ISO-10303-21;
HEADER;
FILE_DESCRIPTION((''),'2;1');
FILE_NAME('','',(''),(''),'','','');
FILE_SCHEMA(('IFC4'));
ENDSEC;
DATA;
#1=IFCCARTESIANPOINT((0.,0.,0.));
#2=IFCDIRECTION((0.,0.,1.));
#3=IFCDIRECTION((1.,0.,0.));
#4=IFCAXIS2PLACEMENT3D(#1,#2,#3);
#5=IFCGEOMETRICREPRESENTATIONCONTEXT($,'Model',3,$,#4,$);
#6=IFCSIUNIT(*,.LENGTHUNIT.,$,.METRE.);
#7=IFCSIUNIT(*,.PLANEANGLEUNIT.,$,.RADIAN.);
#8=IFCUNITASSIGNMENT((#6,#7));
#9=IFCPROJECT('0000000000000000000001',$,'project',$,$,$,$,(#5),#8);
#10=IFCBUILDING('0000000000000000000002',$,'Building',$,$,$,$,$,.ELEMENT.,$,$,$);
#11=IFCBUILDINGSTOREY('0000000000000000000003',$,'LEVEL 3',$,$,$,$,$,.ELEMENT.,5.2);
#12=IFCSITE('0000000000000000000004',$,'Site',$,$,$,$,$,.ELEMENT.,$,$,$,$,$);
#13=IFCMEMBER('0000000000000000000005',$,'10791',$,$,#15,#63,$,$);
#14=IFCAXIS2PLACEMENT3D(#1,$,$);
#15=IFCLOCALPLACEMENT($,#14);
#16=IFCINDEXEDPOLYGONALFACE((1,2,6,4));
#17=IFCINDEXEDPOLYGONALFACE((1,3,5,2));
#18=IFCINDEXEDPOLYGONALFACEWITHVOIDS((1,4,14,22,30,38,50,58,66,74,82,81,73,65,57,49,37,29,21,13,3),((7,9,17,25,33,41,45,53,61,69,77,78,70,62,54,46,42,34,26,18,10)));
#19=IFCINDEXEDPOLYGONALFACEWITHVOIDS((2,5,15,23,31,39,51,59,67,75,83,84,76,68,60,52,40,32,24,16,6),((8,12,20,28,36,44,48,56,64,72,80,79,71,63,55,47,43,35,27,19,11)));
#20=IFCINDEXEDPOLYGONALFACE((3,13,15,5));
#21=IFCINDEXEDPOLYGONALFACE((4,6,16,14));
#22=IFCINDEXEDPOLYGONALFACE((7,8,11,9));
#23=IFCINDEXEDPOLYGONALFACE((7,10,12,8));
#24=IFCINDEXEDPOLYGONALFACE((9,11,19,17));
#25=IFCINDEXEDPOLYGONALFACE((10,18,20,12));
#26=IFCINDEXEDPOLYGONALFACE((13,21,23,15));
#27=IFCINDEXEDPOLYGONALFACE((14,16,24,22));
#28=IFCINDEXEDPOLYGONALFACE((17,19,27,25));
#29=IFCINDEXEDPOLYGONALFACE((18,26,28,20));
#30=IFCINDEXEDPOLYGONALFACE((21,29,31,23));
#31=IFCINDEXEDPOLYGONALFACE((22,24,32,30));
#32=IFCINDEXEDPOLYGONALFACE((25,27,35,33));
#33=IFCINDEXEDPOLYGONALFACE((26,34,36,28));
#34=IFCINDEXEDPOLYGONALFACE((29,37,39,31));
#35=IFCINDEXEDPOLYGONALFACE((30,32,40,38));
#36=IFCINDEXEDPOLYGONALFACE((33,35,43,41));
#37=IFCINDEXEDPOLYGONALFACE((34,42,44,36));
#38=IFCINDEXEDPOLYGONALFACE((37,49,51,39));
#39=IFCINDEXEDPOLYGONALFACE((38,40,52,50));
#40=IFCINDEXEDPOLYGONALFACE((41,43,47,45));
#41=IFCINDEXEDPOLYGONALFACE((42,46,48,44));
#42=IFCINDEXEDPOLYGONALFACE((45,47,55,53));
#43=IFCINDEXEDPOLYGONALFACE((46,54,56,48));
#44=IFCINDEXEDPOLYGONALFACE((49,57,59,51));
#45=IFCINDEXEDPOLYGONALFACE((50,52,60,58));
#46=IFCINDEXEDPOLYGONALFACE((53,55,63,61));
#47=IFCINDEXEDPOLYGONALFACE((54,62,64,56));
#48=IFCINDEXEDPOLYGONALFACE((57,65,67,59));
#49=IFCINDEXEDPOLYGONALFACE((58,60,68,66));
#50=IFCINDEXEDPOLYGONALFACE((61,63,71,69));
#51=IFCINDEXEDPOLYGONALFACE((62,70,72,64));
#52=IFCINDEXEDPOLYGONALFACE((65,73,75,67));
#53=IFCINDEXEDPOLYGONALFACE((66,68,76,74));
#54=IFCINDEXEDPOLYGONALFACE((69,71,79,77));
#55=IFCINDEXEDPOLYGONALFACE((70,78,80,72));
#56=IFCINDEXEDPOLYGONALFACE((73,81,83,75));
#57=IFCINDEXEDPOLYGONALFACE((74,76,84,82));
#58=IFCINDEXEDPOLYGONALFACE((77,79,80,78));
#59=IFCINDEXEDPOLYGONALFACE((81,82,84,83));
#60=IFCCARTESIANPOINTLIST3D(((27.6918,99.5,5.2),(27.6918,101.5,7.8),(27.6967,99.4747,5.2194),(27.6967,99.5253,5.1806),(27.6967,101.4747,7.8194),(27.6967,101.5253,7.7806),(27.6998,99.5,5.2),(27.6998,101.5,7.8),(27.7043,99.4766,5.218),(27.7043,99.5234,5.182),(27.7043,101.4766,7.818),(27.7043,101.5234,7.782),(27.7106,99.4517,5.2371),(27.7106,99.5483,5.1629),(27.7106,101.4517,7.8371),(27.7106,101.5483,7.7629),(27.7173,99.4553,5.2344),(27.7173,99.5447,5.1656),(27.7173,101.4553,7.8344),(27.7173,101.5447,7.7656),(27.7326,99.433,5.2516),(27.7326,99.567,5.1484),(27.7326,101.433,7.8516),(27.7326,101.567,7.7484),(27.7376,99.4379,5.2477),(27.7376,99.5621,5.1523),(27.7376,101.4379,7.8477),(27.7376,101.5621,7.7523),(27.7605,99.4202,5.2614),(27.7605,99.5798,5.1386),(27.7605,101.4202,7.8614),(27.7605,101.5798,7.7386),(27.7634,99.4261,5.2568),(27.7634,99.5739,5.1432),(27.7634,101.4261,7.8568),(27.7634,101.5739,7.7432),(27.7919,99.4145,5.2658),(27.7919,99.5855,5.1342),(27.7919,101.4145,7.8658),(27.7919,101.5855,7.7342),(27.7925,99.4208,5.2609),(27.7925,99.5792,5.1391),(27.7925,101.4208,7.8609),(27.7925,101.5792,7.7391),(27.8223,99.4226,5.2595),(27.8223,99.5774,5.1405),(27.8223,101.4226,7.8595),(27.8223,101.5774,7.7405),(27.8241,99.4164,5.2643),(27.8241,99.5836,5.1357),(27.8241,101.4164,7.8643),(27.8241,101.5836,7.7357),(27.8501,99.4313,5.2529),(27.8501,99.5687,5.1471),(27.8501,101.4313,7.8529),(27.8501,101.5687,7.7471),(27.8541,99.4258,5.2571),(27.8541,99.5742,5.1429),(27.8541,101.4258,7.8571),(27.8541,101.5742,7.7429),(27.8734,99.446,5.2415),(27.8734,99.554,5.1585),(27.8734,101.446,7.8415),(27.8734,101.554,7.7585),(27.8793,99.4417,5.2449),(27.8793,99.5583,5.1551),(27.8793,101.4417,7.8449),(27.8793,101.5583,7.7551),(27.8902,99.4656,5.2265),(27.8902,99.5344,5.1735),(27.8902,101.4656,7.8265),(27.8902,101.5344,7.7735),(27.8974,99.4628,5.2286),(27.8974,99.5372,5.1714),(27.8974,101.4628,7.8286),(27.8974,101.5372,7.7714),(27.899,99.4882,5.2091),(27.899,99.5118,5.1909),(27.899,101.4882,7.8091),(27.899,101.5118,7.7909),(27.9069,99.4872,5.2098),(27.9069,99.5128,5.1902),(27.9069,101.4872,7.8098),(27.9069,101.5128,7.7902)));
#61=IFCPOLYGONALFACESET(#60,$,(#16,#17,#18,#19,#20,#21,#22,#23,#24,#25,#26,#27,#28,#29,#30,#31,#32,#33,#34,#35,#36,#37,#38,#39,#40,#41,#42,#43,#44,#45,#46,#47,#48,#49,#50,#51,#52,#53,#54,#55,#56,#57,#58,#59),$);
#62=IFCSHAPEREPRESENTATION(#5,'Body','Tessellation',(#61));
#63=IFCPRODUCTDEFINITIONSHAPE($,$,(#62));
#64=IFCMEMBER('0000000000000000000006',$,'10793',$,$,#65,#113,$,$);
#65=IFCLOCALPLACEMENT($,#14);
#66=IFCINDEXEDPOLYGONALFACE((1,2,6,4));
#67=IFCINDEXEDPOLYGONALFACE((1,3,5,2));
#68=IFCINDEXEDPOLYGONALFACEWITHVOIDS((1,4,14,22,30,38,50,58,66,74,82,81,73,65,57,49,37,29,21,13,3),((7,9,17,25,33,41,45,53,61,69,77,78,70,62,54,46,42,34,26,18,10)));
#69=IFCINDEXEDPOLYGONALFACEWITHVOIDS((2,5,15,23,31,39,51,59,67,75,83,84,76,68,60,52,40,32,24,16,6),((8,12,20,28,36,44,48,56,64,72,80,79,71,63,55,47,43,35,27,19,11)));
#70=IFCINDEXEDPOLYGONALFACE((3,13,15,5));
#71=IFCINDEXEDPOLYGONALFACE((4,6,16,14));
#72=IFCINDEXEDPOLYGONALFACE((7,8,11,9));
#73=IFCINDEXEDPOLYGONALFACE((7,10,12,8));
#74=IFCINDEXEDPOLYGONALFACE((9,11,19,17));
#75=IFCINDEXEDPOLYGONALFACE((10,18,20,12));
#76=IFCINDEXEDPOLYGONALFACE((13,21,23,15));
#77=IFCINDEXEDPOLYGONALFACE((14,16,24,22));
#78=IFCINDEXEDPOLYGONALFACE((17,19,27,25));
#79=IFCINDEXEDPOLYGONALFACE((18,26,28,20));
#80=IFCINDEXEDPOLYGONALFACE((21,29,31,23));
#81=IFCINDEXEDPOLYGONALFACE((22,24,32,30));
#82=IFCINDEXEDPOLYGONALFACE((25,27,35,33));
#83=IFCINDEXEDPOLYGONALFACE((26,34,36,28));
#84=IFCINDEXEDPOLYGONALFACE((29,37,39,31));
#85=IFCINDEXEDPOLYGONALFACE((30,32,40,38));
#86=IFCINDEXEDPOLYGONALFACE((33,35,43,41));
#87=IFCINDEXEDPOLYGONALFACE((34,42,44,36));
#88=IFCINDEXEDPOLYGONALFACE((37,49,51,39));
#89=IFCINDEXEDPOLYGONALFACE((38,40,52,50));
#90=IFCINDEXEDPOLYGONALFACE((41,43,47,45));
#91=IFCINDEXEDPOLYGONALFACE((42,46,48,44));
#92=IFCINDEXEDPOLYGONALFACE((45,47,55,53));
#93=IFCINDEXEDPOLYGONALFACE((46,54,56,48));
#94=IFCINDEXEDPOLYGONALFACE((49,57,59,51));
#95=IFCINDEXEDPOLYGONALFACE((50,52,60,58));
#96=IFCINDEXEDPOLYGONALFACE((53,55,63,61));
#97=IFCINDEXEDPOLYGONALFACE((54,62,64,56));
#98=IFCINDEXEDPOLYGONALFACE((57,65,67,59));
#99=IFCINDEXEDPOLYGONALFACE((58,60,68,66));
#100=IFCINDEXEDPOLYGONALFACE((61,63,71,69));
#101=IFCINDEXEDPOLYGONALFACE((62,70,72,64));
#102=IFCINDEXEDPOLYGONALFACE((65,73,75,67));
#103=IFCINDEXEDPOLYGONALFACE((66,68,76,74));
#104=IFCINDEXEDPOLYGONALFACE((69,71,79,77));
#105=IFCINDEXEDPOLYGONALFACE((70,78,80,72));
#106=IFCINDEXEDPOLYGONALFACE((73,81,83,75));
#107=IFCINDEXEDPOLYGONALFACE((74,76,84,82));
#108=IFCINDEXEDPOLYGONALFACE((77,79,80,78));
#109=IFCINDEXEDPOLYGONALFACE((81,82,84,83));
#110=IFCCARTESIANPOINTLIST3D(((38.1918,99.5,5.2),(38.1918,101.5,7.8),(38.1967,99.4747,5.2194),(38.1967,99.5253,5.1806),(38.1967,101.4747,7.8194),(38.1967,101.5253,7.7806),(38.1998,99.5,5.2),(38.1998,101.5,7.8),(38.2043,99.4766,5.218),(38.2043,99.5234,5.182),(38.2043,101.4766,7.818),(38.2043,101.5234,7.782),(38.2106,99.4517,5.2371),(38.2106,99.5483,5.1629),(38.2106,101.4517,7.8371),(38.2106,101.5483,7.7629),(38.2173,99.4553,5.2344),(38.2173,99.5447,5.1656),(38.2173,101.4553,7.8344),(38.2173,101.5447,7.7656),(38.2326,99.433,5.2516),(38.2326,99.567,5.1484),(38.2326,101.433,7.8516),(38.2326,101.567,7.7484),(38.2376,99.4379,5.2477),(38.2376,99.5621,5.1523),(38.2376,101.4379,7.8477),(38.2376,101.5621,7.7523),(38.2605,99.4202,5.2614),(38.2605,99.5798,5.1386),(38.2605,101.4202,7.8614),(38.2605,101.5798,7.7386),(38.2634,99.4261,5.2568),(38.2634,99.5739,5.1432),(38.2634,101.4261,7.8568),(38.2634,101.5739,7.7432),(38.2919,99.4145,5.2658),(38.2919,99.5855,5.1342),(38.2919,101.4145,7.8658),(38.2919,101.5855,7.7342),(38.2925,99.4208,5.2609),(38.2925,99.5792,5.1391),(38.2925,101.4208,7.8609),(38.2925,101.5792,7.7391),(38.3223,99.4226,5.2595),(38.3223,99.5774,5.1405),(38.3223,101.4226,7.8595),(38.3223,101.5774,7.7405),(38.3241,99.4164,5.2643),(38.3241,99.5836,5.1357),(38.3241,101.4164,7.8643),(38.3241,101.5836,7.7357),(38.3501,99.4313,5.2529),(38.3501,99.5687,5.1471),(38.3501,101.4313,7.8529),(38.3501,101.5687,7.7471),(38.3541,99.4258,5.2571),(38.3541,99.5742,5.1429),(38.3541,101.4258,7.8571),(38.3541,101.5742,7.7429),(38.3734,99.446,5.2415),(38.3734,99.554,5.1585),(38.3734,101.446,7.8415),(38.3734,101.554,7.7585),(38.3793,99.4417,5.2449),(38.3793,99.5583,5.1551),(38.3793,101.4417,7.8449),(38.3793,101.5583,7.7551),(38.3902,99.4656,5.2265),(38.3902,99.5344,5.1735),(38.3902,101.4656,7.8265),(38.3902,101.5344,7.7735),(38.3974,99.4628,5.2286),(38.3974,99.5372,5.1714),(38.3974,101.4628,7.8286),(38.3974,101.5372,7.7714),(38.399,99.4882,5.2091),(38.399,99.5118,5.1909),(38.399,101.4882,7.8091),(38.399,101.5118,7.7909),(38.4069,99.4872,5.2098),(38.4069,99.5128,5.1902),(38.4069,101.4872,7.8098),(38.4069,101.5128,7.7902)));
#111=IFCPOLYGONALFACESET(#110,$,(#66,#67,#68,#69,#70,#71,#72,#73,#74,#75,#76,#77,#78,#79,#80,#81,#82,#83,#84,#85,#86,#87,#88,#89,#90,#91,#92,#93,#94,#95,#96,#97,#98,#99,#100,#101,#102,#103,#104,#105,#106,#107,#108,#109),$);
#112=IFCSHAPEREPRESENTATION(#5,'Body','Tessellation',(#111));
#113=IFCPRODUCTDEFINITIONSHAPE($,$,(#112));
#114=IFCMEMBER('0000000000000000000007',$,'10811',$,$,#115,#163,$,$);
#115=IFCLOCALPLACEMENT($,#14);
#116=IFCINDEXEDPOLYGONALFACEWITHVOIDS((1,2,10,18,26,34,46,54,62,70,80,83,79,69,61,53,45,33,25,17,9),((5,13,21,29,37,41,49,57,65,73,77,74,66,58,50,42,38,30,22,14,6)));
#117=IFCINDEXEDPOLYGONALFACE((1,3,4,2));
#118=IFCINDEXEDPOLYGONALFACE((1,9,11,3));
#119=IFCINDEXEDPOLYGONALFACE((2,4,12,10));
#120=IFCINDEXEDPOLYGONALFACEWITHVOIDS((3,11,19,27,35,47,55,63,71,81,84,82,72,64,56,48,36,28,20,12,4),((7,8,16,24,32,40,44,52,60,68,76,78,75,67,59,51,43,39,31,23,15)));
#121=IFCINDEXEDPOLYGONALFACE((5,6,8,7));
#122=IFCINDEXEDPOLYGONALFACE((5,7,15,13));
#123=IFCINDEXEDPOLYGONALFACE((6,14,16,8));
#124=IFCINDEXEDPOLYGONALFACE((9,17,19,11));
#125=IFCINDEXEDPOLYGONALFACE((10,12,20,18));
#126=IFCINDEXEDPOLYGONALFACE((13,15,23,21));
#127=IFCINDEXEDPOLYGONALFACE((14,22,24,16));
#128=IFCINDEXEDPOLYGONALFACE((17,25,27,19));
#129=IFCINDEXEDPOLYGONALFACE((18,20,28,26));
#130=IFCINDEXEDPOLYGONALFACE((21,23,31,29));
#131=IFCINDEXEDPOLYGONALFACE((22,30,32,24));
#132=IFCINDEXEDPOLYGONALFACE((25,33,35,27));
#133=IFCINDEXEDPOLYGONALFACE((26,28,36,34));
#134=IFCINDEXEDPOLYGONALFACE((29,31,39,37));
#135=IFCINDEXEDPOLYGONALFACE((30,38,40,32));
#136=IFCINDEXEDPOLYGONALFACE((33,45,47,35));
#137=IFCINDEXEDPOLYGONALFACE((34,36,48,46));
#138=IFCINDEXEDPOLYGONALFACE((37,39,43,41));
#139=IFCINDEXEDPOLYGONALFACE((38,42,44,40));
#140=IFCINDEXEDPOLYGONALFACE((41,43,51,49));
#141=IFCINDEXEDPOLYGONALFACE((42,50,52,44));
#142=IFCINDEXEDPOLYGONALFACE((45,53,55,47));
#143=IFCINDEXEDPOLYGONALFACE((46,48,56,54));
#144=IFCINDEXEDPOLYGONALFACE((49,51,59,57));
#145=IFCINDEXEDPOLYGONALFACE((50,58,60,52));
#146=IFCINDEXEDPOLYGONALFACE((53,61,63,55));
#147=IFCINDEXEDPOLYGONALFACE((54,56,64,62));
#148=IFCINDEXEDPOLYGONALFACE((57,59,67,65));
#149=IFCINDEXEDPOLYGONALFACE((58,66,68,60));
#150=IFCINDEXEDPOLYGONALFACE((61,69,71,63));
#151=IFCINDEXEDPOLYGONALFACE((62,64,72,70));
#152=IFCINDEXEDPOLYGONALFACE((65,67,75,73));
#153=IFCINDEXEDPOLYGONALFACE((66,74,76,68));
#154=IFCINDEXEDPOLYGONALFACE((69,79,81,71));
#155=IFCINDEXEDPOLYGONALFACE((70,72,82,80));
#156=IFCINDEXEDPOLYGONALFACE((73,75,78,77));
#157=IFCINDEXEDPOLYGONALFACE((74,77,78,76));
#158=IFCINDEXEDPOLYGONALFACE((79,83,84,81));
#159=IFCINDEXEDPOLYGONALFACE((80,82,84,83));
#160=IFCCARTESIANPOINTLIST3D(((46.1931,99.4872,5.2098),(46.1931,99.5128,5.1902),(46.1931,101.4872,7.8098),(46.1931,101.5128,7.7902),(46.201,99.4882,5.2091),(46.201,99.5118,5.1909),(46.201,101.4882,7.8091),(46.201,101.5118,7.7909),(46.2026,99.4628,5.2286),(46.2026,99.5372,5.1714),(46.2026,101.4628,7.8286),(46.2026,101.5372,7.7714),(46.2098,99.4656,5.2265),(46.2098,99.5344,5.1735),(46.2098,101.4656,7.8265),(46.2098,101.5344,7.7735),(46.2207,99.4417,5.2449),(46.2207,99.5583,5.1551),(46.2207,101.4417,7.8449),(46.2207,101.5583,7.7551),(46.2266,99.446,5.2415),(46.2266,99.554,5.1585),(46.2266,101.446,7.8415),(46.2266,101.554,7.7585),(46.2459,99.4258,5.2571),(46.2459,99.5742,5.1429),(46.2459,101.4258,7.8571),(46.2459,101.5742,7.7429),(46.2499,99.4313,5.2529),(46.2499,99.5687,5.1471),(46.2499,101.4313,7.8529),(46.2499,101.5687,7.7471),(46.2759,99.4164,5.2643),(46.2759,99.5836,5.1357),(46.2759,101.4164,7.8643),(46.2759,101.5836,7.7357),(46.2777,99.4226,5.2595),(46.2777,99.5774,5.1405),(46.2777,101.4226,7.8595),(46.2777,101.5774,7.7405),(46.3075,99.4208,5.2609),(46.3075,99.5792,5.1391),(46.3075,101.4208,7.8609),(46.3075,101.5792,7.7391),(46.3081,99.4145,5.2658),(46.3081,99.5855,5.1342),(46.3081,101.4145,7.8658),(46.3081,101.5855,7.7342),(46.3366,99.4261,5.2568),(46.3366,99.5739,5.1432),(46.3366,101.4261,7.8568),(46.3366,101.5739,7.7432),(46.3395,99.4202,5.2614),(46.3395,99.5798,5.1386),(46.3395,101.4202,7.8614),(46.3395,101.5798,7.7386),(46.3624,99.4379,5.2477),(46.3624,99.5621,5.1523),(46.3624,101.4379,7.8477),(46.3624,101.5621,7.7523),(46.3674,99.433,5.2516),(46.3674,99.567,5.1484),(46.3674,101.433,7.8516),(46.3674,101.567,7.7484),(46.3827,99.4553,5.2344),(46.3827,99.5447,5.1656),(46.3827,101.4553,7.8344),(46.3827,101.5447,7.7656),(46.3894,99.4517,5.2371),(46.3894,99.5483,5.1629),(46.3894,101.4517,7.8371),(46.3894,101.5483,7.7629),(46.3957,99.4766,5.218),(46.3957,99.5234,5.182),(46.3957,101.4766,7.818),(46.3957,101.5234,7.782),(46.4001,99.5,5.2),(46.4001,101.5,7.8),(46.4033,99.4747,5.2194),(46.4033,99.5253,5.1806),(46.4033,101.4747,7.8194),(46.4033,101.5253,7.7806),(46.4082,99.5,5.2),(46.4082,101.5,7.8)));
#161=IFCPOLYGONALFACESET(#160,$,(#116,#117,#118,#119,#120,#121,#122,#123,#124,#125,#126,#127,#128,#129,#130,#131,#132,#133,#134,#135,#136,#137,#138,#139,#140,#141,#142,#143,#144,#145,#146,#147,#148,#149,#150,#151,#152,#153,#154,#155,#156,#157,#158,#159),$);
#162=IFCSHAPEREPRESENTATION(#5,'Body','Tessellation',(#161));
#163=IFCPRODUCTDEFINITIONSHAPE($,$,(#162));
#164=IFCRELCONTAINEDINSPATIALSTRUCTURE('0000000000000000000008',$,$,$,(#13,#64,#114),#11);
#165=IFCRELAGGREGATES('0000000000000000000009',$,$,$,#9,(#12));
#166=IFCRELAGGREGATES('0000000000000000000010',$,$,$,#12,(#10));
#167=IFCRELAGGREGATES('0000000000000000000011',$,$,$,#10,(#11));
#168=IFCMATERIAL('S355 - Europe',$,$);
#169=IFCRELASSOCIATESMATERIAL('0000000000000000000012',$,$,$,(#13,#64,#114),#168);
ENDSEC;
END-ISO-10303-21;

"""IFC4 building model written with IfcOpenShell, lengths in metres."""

from ifc_helpers import new_model, si_unit, frame, origin_with_axes, origin_2d_with_axis, place, context, project, spatial, hollow_circle, extrude, material, material_profile, profile_set, profile_usage, element, save


model = new_model("IFC4")

# Units and contexts
model_context = context("Model", 3, world=origin_with_axes())
ifc_project = project(units=[si_unit("LENGTHUNIT", "METRE"), si_unit("PLANEANGLEUNIT", "RADIAN")], contexts=[model_context])

# Site, building, storey
site = spatial("IfcSite", under=ifc_project, Name="Site", CompositionType="ELEMENT")
building = spatial("IfcBuilding", under=site, Name="Building", CompositionType="ELEMENT")
storey = spatial("IfcBuildingStorey", under=building, Name="LEVEL 3", CompositionType="ELEMENT", Elevation=5.2)

# Shared definitions
ifc_material = material(Name="S355 - Europe")

# Members
ifc_material_profile_1 = material_profile(ifc_material, hollow_circle(Radius=0.1081, WallThickness=0.008, at=origin_2d_with_axis()))
ifc_profile_set_1 = profile_set([ifc_material_profile_1])
ifc_profile_usage_1 = profile_usage(ifc_profile_set_1, cardinal=10)
member_1_placement = place(None, frame((27.8, 99.5, 5.2), z_axis=(0.0, 0.609711, 0.792624), x_axis=(-1.0, 0.0, 0.0)))
element("IfcMember", 1, at=member_1_placement, inside=storey, material=ifc_profile_usage_1, Name="10791", context=model_context, shape_type="SweptSolid", body=[
    extrude(hollow_circle(Radius=0.1081, WallThickness=0.008, at=origin_2d_with_axis()), origin_with_axes(), (0.0, 0.0, 1.0), 3.2802),
])
ifc_material_profile_2 = material_profile(ifc_material, hollow_circle(Radius=0.1081, WallThickness=0.008, at=origin_2d_with_axis()))
ifc_profile_set_2 = profile_set([ifc_material_profile_2])
ifc_profile_usage_2 = profile_usage(ifc_profile_set_2, cardinal=10)
member_2_placement = place(None, frame((38.3, 99.5, 5.2), z_axis=(0.0, 0.609711, 0.792624), x_axis=(-1.0, 0.0, 0.0)))
element("IfcMember", 2, at=member_2_placement, inside=storey, material=ifc_profile_usage_2, Name="10793", context=model_context, shape_type="SweptSolid", body=[
    extrude(hollow_circle(Radius=0.1081, WallThickness=0.008, at=origin_2d_with_axis()), origin_with_axes(), (0.0, 0.0, 1.0), 3.2802),
])
ifc_material_profile_3 = material_profile(ifc_material, hollow_circle(Radius=0.1081, WallThickness=0.008, at=origin_2d_with_axis()))
ifc_profile_set_3 = profile_set([ifc_material_profile_3])
ifc_profile_usage_3 = profile_usage(ifc_profile_set_3, cardinal=10)
member_3_placement = place(None, frame((46.3, 101.5, 7.8), z_axis=(0.0, -0.609711, -0.792624), x_axis=(1.0, 0.0, 0.0)))
element("IfcMember", 3, at=member_3_placement, inside=storey, material=ifc_profile_usage_3, Name="10811", context=model_context, shape_type="SweptSolid", body=[
    extrude(hollow_circle(Radius=0.1081, WallThickness=0.008, at=origin_2d_with_axis()), origin_with_axes(), (0.0, 0.0, 1.0), 3.2802),
])

save(model, "model.ifc")
